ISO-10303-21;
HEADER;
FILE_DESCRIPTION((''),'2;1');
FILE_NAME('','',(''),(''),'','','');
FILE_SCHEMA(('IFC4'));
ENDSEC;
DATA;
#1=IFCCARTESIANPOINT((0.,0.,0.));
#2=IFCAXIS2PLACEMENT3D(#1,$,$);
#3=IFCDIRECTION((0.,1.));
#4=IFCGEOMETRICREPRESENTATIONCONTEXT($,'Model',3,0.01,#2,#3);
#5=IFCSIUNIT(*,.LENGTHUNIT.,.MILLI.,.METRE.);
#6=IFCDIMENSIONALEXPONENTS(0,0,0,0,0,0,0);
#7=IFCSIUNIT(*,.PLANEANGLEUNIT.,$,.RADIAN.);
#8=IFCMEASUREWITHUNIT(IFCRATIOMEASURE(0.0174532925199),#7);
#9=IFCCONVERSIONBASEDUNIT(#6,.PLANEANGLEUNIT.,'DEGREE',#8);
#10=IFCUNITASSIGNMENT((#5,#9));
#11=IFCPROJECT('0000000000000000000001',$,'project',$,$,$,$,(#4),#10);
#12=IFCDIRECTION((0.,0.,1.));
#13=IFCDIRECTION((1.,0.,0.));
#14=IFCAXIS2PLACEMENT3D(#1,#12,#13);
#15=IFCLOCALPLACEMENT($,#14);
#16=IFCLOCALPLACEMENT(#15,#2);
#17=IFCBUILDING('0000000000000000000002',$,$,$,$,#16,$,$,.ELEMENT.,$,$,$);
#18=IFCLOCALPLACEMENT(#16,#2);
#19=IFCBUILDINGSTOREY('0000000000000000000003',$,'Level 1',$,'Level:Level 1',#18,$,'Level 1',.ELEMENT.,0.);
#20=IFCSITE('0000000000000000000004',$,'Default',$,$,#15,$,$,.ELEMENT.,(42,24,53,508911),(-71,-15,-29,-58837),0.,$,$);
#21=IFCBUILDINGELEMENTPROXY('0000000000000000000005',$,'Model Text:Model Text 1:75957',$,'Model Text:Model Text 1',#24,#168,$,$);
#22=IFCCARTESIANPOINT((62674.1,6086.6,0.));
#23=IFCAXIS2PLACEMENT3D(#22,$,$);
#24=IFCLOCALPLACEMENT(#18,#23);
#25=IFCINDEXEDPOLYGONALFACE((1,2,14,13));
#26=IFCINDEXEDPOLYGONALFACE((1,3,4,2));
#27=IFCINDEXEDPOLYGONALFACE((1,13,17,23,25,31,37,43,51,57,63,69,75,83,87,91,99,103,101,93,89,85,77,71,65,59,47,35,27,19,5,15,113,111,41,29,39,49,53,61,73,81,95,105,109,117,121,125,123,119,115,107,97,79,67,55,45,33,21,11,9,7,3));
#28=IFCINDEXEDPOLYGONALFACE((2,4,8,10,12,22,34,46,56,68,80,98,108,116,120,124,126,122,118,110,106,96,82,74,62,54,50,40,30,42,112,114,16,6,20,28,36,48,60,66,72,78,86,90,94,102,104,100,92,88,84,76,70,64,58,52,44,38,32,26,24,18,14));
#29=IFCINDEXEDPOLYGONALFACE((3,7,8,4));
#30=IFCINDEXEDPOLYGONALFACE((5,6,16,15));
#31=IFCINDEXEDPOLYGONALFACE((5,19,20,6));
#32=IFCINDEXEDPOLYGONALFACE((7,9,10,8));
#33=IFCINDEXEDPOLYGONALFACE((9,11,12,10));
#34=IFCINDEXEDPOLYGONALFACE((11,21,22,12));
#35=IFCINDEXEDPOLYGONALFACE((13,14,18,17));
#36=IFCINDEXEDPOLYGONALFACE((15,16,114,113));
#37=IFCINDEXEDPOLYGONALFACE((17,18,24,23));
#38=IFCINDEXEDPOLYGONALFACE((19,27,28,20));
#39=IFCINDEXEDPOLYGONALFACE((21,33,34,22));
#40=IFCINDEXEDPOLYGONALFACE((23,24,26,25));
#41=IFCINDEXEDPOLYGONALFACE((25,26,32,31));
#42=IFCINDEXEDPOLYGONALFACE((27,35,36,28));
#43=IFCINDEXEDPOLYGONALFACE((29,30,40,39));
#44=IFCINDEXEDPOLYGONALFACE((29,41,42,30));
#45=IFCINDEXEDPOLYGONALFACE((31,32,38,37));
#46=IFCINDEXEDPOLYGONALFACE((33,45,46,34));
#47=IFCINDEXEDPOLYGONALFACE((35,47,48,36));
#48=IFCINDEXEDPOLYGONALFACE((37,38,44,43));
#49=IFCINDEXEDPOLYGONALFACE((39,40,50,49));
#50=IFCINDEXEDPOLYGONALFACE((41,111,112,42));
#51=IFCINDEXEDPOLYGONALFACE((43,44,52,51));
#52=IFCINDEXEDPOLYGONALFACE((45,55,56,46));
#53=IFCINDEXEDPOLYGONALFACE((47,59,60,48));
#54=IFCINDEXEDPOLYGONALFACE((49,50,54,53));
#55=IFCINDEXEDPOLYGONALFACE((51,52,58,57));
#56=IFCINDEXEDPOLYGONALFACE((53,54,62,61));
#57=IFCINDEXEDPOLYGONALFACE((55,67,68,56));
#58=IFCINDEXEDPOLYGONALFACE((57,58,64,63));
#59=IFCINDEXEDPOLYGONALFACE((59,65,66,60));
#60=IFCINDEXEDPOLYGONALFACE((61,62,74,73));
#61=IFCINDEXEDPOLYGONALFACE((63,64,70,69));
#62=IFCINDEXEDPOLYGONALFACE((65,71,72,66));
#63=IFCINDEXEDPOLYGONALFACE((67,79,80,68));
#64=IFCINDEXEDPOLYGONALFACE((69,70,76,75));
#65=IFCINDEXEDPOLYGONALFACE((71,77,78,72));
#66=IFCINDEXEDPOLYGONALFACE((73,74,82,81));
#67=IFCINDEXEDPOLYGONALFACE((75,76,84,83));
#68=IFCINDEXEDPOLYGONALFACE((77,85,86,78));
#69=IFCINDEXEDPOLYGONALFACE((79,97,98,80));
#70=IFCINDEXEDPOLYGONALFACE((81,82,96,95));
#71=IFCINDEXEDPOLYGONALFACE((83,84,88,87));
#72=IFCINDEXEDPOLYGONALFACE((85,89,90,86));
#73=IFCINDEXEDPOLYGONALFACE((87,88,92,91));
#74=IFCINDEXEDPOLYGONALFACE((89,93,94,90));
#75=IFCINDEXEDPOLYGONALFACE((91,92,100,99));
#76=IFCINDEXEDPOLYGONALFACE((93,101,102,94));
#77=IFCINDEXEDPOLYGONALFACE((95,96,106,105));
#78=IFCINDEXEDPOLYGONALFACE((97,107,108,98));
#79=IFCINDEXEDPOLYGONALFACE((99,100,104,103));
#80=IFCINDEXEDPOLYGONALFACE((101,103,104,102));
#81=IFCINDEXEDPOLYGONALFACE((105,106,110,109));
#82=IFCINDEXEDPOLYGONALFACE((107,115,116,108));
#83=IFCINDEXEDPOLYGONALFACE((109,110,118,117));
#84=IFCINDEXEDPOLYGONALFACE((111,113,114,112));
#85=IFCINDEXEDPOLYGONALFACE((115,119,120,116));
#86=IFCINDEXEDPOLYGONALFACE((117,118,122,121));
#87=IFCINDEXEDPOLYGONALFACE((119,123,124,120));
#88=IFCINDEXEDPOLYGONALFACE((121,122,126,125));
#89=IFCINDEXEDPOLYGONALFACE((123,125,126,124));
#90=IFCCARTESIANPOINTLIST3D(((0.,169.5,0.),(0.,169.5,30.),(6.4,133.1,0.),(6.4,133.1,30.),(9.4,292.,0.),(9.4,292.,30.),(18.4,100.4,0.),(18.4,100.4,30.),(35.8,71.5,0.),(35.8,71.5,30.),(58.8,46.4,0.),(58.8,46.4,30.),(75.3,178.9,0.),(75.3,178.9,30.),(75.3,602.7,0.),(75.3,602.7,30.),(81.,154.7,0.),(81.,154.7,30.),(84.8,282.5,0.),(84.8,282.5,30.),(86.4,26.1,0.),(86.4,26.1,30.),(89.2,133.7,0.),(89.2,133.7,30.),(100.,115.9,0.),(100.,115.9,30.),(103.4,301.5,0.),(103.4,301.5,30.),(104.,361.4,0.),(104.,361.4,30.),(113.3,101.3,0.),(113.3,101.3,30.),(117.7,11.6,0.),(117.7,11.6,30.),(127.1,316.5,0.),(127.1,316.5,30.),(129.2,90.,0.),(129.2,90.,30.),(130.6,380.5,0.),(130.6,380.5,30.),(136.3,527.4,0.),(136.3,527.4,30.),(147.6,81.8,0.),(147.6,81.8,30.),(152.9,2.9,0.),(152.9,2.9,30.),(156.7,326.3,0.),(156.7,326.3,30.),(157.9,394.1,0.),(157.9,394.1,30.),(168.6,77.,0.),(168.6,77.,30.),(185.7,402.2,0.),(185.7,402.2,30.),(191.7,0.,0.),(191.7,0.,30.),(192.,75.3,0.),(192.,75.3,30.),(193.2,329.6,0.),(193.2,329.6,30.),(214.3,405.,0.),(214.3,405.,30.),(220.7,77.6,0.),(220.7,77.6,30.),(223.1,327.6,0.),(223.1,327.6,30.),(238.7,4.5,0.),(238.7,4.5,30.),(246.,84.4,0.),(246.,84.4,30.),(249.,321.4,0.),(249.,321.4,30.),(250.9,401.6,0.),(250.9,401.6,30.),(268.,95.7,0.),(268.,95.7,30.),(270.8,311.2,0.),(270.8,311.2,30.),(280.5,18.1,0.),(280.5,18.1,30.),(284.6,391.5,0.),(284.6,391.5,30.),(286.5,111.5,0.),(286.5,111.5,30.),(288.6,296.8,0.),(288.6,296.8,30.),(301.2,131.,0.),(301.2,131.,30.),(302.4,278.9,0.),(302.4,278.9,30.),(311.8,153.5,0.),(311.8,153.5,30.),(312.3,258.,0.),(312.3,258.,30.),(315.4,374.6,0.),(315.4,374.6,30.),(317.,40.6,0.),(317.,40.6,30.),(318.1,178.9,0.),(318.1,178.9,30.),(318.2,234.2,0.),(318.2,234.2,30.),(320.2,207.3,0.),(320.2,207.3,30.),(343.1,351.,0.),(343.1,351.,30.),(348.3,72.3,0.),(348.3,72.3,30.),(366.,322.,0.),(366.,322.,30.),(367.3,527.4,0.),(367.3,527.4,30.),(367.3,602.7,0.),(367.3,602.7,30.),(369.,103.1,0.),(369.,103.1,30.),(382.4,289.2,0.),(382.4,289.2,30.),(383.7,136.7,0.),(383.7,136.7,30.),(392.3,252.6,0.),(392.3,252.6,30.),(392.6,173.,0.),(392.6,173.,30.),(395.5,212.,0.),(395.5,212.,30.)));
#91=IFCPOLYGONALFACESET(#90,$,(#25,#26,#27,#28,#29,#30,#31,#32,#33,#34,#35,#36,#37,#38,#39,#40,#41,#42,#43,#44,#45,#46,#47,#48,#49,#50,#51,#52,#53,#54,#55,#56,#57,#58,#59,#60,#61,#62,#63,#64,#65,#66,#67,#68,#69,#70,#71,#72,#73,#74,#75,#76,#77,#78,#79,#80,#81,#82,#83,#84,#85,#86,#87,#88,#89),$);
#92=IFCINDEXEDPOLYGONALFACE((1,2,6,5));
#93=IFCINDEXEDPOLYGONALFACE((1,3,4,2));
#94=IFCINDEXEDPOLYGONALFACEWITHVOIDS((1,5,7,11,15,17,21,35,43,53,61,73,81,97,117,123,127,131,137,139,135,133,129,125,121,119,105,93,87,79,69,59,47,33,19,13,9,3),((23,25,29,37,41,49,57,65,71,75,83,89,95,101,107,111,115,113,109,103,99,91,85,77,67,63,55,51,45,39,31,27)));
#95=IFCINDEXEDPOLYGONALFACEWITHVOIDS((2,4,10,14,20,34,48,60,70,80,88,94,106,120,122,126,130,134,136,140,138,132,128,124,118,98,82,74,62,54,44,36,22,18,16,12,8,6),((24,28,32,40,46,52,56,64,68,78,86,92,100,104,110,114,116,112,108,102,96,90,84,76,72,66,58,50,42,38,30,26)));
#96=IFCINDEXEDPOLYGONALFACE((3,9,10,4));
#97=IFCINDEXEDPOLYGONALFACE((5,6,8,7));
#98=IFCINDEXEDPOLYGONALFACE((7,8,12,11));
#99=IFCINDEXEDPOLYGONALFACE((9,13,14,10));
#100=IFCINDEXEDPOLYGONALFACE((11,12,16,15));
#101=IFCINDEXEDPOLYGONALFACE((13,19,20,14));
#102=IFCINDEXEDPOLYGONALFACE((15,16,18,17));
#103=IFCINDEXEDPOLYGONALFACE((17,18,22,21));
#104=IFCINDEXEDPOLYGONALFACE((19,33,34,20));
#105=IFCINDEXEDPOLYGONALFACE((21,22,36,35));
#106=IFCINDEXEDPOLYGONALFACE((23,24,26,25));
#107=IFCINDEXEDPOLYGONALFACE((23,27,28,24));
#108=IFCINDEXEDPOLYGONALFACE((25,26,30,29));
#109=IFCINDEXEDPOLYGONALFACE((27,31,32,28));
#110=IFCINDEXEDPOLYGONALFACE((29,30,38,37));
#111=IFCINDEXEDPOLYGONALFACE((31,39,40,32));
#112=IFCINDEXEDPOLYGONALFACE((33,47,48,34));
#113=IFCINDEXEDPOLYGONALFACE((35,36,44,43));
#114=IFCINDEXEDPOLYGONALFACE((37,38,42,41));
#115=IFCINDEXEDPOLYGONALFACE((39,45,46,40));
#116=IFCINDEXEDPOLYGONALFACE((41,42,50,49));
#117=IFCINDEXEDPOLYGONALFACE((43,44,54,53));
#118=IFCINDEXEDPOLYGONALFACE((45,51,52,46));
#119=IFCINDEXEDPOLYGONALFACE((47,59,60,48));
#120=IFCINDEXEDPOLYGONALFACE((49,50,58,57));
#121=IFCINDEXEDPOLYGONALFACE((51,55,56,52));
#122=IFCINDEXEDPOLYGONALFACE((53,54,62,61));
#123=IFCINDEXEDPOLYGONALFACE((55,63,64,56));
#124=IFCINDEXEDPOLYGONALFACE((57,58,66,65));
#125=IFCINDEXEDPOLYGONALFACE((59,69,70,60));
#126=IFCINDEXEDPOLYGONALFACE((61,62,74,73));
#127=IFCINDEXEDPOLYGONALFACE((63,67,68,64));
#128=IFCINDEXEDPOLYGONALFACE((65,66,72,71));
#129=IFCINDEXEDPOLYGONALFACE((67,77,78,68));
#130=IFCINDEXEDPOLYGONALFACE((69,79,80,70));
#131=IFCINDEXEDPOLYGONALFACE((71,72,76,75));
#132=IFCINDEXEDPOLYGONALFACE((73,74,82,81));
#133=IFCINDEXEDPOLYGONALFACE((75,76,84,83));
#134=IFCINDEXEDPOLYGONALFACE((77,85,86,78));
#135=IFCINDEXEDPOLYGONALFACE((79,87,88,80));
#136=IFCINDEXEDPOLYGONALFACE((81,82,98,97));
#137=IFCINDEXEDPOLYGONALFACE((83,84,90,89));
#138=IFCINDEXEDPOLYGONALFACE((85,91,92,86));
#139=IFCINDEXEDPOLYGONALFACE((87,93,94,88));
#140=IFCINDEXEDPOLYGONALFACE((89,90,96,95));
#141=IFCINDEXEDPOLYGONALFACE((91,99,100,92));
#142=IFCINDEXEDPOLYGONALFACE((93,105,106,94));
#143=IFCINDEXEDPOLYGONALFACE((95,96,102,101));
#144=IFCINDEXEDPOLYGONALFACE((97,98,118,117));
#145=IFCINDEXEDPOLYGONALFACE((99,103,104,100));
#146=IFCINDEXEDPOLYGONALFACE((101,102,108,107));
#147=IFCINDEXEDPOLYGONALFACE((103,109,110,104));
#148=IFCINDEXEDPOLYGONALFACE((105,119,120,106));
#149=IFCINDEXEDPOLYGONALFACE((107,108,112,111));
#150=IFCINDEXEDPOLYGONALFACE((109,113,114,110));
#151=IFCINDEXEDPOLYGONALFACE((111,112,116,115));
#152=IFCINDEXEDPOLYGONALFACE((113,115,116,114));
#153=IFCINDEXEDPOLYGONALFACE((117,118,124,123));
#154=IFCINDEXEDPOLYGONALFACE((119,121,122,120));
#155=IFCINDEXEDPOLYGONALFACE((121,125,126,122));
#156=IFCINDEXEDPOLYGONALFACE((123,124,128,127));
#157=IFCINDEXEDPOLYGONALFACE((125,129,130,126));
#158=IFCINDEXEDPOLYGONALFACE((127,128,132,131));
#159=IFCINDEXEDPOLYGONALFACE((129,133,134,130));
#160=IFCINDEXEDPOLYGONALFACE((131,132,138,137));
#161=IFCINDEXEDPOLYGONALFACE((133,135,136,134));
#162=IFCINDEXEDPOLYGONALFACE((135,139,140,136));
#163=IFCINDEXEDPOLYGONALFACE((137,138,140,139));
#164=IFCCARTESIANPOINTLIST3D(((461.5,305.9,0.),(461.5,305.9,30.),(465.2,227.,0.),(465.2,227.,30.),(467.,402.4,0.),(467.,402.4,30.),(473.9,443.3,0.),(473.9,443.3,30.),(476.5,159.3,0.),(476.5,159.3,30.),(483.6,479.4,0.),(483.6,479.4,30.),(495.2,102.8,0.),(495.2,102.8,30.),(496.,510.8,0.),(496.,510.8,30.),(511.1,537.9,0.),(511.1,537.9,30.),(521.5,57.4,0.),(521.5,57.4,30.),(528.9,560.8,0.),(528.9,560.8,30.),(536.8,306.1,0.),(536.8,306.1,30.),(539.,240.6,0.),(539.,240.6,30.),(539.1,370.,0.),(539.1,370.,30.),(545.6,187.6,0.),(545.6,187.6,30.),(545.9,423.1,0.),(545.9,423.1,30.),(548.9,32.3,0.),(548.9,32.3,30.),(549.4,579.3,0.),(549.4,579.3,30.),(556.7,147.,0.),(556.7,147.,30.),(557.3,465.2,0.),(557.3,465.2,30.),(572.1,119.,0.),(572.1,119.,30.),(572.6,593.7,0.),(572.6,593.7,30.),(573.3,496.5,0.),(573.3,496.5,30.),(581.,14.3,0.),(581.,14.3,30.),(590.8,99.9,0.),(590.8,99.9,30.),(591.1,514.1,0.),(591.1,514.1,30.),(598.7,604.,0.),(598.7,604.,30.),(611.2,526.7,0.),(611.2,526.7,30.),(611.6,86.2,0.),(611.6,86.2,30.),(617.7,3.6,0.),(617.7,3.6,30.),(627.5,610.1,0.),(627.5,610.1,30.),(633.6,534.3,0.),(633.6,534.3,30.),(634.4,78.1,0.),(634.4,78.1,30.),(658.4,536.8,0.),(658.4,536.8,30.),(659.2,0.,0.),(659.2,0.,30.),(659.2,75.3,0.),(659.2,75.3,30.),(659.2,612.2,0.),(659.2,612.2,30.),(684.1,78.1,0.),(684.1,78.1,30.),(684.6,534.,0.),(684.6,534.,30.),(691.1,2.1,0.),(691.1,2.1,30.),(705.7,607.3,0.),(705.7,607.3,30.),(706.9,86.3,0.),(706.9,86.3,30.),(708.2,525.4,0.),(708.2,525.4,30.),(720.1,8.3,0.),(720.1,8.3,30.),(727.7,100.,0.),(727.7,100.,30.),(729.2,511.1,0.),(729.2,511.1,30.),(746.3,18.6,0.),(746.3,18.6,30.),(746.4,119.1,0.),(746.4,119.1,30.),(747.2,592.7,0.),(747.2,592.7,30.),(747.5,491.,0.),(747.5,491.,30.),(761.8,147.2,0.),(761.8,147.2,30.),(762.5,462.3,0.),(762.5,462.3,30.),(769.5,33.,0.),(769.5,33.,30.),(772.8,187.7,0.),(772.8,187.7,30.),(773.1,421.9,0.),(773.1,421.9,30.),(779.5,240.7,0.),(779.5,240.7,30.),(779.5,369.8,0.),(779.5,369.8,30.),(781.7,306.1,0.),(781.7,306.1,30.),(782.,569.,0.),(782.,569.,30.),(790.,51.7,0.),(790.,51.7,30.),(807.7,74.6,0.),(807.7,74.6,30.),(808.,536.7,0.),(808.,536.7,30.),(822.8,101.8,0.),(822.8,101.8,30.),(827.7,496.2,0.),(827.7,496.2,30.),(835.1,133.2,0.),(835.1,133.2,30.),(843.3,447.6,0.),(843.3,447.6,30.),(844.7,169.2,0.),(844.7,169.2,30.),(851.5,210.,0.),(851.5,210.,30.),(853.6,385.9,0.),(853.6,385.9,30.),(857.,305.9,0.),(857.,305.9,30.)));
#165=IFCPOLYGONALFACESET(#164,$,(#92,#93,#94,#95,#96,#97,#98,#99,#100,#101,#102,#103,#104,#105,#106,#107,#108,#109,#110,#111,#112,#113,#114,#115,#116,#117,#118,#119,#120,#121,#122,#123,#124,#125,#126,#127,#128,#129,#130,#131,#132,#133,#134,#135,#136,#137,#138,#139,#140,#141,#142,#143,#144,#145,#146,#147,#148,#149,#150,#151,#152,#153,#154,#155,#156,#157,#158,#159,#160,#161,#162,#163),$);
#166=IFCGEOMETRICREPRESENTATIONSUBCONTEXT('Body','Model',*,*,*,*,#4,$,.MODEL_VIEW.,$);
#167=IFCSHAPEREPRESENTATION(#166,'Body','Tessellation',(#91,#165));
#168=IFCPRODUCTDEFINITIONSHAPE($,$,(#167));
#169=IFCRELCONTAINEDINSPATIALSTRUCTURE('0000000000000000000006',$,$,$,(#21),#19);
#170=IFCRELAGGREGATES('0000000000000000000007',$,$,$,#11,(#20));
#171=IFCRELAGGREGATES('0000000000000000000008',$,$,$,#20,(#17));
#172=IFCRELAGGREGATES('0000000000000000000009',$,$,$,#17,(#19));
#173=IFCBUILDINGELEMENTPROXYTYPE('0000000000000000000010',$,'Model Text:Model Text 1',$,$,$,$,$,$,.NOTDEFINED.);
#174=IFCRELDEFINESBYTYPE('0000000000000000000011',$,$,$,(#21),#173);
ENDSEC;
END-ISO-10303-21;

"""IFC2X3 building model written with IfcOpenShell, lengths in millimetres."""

from ifc_helpers import new_model, entity, si_unit, converted_unit, direction, frame, origin, origin_with_axes, place, context, subcontext, project, spatial, polyline, outline, extrude, type_object, element, save


model = new_model("IFC2X3")

# Units and contexts
model_context = context("Model", 3, precision=0.01, world=origin(), true_north=direction((0.0, 1.0)))
body_context = subcontext(model_context, "Body", "Model", "MODEL_VIEW")
ifc_project = project(units=[si_unit("LENGTHUNIT", "METRE", prefix="MILLI"), converted_unit("PLANEANGLEUNIT", "DEGREE", entity("IfcRatioMeasure", 0.0174532925199), si_unit("PLANEANGLEUNIT", "RADIAN"), dimensions=[0, 0, 0, 0, 0, 0, 0])], contexts=[model_context])

# Site, building, storey
site_placement = place(None, origin_with_axes())
site = spatial("IfcSite", under=ifc_project, at=site_placement, Name="Default", CompositionType="ELEMENT", RefLatitude=(42, 24, 53, 508911), RefLongitude=(-71, -15, -29, -58837), RefElevation=0.0)
building_placement = place(site_placement, origin())
building = spatial("IfcBuilding", under=site, at=building_placement, CompositionType="ELEMENT")
storey_placement = place(building_placement, origin())
storey = spatial("IfcBuildingStorey", under=building, at=storey_placement, Name="Level 1", ObjectType="Level:Level 1", LongName="Level 1", CompositionType="ELEMENT", Elevation=0.0)

# Building element proxy
building_element_proxy_type_1 = type_object("IfcBuildingElementProxyType", Name="Model Text:Model Text 1", PredefinedType="NOTDEFINED")
proxy_1_placement = place(storey_placement, frame((62674.1, 6086.6, 0.0)))
element("IfcBuildingElementProxy", 1, at=proxy_1_placement, inside=storey, type_object=building_element_proxy_type_1, Name="Model Text:Model Text 1:75957", ObjectType="Model Text:Model Text 1", context=body_context, shape_type="SweptSolid", body=[
    extrude(outline(polyline([(12.1, -219.3), (49.1, -219.3), (83.4, -213.2), (114.8, -201.1), (143.5, -182.8), (168.3, -159.2), (188.1, -130.8), (202.8, -97.8), (212.4, -60.0), (216.1, -12.9), (210.0, 30.5), (194.1, 70.4), (168.4, 106.8), (141.6, 132.5), (111.1, 152.9), (76.9, 167.9), (39.0, 177.6), (-1.5, 181.4), (-39.3, 178.1), (-74.4, 167.6), (-106.9, 150.1), (-135.0, 126.9), (-157.0, 99.6), (-172.8, 68.1), (-182.5, 32.6), (-184.8, 4.0), (-181.6, -24.8), (-172.9, -54.0), (-158.8, -83.5), (-316.6, -22.9), (-276.5, 204.6), (-350.7, 217.7), (-401.4, -69.8), (-106.8, -188.8), (-84.5, -116.2), (-99.9, -94.5), (-110.6, -68.6), (-115.1, -37.8), (-112.0, -1.2), (-104.8, 27.9), (-94.2, 52.3), (-80.3, 72.0), (-63.1, 87.0), (-43.0, 97.5), (-20.8, 103.6), (3.8, 105.3), (30.5, 102.6), (58.1, 95.6), (82.1, 84.9), (102.4, 70.6), (119.1, 52.7), (131.4, 31.7), (138.7, 8.2), (141.0, -17.9), (138.2, -46.6), (132.6, -69.4), (124.1, -89.2), (112.9, -105.9), (99.0, -119.6), (82.3, -130.2), (62.9, -137.7), (40.8, -142.2), (15.9, -143.5), (12.1, -219.3)])), frame((213.9, 219.6, 0.0), z_axis=(0.0, 0.0, 1.0), x_axis=(0.173842, -0.984774, 0.0)), (0.0, 0.0, 1.0), 30.0),
    extrude(outline(polyline([(-10.6, -198.7), (68.3, -198.7), (136.5, -190.7), (193.9, -174.7), (240.5, -150.6), (266.9, -124.4), (286.3, -93.2), (298.8, -57.0), (304.3, -15.7), (303.8, 16.2), (299.0, 45.5), (289.9, 72.1), (276.6, 96.0), (258.9, 117.3), (236.9, 136.2), (210.4, 152.5), (179.6, 166.3), (144.1, 177.6), (103.7, 186.3), (8.2, 196.4), (-71.8, 196.7), (-134.0, 189.4), (-183.3, 176.1), (-224.7, 158.4), (-258.2, 133.9), (-283.5, 100.3), (-300.1, 59.5), (-307.1, 13.4), (-306.6, -18.4), (-301.8, -47.5), (-292.8, -74.0), (-279.6, -97.9), (-262.0, -119.2), (-240.0, -138.1), (-213.6, -154.5), (-182.8, -168.4), (-147.3, -179.8), (-106.7, -188.6), (-10.6, -198.7)]), holes=[polyline([(-7.2, -123.5), (-71.0, -118.2), (-123.6, -108.8), (-165.2, -95.4), (-195.7, -78.0), (-212.4, -59.4), (-224.1, -38.7), (-230.6, -15.9), (-231.9, 8.9), (-227.8, 35.0), (-218.1, 58.1), (-202.8, 78.4), (-182.0, 95.8), (-152.6, 109.4), (-111.7, 118.1), (-59.4, 122.0), (4.4, 121.1), (69.6, 115.8), (122.2, 106.7), (162.2, 93.7), (189.5, 77.0), (207.7, 57.4), (220.4, 36.0), (227.5, 12.8), (229.1, -12.1), (225.2, -36.8), (215.9, -59.2), (201.3, -79.3), (181.4, -97.1), (152.6, -111.2), (111.6, -120.3), (58.3, -124.4), (-7.2, -123.5)])]), frame((660.5, 304.7, 0.0), z_axis=(0.0, 0.0, 1.0), x_axis=(0.047515, -0.998871, 0.0)), (0.0, 0.0, 1.0), 30.0),
])

save(model, "model.ifc")
